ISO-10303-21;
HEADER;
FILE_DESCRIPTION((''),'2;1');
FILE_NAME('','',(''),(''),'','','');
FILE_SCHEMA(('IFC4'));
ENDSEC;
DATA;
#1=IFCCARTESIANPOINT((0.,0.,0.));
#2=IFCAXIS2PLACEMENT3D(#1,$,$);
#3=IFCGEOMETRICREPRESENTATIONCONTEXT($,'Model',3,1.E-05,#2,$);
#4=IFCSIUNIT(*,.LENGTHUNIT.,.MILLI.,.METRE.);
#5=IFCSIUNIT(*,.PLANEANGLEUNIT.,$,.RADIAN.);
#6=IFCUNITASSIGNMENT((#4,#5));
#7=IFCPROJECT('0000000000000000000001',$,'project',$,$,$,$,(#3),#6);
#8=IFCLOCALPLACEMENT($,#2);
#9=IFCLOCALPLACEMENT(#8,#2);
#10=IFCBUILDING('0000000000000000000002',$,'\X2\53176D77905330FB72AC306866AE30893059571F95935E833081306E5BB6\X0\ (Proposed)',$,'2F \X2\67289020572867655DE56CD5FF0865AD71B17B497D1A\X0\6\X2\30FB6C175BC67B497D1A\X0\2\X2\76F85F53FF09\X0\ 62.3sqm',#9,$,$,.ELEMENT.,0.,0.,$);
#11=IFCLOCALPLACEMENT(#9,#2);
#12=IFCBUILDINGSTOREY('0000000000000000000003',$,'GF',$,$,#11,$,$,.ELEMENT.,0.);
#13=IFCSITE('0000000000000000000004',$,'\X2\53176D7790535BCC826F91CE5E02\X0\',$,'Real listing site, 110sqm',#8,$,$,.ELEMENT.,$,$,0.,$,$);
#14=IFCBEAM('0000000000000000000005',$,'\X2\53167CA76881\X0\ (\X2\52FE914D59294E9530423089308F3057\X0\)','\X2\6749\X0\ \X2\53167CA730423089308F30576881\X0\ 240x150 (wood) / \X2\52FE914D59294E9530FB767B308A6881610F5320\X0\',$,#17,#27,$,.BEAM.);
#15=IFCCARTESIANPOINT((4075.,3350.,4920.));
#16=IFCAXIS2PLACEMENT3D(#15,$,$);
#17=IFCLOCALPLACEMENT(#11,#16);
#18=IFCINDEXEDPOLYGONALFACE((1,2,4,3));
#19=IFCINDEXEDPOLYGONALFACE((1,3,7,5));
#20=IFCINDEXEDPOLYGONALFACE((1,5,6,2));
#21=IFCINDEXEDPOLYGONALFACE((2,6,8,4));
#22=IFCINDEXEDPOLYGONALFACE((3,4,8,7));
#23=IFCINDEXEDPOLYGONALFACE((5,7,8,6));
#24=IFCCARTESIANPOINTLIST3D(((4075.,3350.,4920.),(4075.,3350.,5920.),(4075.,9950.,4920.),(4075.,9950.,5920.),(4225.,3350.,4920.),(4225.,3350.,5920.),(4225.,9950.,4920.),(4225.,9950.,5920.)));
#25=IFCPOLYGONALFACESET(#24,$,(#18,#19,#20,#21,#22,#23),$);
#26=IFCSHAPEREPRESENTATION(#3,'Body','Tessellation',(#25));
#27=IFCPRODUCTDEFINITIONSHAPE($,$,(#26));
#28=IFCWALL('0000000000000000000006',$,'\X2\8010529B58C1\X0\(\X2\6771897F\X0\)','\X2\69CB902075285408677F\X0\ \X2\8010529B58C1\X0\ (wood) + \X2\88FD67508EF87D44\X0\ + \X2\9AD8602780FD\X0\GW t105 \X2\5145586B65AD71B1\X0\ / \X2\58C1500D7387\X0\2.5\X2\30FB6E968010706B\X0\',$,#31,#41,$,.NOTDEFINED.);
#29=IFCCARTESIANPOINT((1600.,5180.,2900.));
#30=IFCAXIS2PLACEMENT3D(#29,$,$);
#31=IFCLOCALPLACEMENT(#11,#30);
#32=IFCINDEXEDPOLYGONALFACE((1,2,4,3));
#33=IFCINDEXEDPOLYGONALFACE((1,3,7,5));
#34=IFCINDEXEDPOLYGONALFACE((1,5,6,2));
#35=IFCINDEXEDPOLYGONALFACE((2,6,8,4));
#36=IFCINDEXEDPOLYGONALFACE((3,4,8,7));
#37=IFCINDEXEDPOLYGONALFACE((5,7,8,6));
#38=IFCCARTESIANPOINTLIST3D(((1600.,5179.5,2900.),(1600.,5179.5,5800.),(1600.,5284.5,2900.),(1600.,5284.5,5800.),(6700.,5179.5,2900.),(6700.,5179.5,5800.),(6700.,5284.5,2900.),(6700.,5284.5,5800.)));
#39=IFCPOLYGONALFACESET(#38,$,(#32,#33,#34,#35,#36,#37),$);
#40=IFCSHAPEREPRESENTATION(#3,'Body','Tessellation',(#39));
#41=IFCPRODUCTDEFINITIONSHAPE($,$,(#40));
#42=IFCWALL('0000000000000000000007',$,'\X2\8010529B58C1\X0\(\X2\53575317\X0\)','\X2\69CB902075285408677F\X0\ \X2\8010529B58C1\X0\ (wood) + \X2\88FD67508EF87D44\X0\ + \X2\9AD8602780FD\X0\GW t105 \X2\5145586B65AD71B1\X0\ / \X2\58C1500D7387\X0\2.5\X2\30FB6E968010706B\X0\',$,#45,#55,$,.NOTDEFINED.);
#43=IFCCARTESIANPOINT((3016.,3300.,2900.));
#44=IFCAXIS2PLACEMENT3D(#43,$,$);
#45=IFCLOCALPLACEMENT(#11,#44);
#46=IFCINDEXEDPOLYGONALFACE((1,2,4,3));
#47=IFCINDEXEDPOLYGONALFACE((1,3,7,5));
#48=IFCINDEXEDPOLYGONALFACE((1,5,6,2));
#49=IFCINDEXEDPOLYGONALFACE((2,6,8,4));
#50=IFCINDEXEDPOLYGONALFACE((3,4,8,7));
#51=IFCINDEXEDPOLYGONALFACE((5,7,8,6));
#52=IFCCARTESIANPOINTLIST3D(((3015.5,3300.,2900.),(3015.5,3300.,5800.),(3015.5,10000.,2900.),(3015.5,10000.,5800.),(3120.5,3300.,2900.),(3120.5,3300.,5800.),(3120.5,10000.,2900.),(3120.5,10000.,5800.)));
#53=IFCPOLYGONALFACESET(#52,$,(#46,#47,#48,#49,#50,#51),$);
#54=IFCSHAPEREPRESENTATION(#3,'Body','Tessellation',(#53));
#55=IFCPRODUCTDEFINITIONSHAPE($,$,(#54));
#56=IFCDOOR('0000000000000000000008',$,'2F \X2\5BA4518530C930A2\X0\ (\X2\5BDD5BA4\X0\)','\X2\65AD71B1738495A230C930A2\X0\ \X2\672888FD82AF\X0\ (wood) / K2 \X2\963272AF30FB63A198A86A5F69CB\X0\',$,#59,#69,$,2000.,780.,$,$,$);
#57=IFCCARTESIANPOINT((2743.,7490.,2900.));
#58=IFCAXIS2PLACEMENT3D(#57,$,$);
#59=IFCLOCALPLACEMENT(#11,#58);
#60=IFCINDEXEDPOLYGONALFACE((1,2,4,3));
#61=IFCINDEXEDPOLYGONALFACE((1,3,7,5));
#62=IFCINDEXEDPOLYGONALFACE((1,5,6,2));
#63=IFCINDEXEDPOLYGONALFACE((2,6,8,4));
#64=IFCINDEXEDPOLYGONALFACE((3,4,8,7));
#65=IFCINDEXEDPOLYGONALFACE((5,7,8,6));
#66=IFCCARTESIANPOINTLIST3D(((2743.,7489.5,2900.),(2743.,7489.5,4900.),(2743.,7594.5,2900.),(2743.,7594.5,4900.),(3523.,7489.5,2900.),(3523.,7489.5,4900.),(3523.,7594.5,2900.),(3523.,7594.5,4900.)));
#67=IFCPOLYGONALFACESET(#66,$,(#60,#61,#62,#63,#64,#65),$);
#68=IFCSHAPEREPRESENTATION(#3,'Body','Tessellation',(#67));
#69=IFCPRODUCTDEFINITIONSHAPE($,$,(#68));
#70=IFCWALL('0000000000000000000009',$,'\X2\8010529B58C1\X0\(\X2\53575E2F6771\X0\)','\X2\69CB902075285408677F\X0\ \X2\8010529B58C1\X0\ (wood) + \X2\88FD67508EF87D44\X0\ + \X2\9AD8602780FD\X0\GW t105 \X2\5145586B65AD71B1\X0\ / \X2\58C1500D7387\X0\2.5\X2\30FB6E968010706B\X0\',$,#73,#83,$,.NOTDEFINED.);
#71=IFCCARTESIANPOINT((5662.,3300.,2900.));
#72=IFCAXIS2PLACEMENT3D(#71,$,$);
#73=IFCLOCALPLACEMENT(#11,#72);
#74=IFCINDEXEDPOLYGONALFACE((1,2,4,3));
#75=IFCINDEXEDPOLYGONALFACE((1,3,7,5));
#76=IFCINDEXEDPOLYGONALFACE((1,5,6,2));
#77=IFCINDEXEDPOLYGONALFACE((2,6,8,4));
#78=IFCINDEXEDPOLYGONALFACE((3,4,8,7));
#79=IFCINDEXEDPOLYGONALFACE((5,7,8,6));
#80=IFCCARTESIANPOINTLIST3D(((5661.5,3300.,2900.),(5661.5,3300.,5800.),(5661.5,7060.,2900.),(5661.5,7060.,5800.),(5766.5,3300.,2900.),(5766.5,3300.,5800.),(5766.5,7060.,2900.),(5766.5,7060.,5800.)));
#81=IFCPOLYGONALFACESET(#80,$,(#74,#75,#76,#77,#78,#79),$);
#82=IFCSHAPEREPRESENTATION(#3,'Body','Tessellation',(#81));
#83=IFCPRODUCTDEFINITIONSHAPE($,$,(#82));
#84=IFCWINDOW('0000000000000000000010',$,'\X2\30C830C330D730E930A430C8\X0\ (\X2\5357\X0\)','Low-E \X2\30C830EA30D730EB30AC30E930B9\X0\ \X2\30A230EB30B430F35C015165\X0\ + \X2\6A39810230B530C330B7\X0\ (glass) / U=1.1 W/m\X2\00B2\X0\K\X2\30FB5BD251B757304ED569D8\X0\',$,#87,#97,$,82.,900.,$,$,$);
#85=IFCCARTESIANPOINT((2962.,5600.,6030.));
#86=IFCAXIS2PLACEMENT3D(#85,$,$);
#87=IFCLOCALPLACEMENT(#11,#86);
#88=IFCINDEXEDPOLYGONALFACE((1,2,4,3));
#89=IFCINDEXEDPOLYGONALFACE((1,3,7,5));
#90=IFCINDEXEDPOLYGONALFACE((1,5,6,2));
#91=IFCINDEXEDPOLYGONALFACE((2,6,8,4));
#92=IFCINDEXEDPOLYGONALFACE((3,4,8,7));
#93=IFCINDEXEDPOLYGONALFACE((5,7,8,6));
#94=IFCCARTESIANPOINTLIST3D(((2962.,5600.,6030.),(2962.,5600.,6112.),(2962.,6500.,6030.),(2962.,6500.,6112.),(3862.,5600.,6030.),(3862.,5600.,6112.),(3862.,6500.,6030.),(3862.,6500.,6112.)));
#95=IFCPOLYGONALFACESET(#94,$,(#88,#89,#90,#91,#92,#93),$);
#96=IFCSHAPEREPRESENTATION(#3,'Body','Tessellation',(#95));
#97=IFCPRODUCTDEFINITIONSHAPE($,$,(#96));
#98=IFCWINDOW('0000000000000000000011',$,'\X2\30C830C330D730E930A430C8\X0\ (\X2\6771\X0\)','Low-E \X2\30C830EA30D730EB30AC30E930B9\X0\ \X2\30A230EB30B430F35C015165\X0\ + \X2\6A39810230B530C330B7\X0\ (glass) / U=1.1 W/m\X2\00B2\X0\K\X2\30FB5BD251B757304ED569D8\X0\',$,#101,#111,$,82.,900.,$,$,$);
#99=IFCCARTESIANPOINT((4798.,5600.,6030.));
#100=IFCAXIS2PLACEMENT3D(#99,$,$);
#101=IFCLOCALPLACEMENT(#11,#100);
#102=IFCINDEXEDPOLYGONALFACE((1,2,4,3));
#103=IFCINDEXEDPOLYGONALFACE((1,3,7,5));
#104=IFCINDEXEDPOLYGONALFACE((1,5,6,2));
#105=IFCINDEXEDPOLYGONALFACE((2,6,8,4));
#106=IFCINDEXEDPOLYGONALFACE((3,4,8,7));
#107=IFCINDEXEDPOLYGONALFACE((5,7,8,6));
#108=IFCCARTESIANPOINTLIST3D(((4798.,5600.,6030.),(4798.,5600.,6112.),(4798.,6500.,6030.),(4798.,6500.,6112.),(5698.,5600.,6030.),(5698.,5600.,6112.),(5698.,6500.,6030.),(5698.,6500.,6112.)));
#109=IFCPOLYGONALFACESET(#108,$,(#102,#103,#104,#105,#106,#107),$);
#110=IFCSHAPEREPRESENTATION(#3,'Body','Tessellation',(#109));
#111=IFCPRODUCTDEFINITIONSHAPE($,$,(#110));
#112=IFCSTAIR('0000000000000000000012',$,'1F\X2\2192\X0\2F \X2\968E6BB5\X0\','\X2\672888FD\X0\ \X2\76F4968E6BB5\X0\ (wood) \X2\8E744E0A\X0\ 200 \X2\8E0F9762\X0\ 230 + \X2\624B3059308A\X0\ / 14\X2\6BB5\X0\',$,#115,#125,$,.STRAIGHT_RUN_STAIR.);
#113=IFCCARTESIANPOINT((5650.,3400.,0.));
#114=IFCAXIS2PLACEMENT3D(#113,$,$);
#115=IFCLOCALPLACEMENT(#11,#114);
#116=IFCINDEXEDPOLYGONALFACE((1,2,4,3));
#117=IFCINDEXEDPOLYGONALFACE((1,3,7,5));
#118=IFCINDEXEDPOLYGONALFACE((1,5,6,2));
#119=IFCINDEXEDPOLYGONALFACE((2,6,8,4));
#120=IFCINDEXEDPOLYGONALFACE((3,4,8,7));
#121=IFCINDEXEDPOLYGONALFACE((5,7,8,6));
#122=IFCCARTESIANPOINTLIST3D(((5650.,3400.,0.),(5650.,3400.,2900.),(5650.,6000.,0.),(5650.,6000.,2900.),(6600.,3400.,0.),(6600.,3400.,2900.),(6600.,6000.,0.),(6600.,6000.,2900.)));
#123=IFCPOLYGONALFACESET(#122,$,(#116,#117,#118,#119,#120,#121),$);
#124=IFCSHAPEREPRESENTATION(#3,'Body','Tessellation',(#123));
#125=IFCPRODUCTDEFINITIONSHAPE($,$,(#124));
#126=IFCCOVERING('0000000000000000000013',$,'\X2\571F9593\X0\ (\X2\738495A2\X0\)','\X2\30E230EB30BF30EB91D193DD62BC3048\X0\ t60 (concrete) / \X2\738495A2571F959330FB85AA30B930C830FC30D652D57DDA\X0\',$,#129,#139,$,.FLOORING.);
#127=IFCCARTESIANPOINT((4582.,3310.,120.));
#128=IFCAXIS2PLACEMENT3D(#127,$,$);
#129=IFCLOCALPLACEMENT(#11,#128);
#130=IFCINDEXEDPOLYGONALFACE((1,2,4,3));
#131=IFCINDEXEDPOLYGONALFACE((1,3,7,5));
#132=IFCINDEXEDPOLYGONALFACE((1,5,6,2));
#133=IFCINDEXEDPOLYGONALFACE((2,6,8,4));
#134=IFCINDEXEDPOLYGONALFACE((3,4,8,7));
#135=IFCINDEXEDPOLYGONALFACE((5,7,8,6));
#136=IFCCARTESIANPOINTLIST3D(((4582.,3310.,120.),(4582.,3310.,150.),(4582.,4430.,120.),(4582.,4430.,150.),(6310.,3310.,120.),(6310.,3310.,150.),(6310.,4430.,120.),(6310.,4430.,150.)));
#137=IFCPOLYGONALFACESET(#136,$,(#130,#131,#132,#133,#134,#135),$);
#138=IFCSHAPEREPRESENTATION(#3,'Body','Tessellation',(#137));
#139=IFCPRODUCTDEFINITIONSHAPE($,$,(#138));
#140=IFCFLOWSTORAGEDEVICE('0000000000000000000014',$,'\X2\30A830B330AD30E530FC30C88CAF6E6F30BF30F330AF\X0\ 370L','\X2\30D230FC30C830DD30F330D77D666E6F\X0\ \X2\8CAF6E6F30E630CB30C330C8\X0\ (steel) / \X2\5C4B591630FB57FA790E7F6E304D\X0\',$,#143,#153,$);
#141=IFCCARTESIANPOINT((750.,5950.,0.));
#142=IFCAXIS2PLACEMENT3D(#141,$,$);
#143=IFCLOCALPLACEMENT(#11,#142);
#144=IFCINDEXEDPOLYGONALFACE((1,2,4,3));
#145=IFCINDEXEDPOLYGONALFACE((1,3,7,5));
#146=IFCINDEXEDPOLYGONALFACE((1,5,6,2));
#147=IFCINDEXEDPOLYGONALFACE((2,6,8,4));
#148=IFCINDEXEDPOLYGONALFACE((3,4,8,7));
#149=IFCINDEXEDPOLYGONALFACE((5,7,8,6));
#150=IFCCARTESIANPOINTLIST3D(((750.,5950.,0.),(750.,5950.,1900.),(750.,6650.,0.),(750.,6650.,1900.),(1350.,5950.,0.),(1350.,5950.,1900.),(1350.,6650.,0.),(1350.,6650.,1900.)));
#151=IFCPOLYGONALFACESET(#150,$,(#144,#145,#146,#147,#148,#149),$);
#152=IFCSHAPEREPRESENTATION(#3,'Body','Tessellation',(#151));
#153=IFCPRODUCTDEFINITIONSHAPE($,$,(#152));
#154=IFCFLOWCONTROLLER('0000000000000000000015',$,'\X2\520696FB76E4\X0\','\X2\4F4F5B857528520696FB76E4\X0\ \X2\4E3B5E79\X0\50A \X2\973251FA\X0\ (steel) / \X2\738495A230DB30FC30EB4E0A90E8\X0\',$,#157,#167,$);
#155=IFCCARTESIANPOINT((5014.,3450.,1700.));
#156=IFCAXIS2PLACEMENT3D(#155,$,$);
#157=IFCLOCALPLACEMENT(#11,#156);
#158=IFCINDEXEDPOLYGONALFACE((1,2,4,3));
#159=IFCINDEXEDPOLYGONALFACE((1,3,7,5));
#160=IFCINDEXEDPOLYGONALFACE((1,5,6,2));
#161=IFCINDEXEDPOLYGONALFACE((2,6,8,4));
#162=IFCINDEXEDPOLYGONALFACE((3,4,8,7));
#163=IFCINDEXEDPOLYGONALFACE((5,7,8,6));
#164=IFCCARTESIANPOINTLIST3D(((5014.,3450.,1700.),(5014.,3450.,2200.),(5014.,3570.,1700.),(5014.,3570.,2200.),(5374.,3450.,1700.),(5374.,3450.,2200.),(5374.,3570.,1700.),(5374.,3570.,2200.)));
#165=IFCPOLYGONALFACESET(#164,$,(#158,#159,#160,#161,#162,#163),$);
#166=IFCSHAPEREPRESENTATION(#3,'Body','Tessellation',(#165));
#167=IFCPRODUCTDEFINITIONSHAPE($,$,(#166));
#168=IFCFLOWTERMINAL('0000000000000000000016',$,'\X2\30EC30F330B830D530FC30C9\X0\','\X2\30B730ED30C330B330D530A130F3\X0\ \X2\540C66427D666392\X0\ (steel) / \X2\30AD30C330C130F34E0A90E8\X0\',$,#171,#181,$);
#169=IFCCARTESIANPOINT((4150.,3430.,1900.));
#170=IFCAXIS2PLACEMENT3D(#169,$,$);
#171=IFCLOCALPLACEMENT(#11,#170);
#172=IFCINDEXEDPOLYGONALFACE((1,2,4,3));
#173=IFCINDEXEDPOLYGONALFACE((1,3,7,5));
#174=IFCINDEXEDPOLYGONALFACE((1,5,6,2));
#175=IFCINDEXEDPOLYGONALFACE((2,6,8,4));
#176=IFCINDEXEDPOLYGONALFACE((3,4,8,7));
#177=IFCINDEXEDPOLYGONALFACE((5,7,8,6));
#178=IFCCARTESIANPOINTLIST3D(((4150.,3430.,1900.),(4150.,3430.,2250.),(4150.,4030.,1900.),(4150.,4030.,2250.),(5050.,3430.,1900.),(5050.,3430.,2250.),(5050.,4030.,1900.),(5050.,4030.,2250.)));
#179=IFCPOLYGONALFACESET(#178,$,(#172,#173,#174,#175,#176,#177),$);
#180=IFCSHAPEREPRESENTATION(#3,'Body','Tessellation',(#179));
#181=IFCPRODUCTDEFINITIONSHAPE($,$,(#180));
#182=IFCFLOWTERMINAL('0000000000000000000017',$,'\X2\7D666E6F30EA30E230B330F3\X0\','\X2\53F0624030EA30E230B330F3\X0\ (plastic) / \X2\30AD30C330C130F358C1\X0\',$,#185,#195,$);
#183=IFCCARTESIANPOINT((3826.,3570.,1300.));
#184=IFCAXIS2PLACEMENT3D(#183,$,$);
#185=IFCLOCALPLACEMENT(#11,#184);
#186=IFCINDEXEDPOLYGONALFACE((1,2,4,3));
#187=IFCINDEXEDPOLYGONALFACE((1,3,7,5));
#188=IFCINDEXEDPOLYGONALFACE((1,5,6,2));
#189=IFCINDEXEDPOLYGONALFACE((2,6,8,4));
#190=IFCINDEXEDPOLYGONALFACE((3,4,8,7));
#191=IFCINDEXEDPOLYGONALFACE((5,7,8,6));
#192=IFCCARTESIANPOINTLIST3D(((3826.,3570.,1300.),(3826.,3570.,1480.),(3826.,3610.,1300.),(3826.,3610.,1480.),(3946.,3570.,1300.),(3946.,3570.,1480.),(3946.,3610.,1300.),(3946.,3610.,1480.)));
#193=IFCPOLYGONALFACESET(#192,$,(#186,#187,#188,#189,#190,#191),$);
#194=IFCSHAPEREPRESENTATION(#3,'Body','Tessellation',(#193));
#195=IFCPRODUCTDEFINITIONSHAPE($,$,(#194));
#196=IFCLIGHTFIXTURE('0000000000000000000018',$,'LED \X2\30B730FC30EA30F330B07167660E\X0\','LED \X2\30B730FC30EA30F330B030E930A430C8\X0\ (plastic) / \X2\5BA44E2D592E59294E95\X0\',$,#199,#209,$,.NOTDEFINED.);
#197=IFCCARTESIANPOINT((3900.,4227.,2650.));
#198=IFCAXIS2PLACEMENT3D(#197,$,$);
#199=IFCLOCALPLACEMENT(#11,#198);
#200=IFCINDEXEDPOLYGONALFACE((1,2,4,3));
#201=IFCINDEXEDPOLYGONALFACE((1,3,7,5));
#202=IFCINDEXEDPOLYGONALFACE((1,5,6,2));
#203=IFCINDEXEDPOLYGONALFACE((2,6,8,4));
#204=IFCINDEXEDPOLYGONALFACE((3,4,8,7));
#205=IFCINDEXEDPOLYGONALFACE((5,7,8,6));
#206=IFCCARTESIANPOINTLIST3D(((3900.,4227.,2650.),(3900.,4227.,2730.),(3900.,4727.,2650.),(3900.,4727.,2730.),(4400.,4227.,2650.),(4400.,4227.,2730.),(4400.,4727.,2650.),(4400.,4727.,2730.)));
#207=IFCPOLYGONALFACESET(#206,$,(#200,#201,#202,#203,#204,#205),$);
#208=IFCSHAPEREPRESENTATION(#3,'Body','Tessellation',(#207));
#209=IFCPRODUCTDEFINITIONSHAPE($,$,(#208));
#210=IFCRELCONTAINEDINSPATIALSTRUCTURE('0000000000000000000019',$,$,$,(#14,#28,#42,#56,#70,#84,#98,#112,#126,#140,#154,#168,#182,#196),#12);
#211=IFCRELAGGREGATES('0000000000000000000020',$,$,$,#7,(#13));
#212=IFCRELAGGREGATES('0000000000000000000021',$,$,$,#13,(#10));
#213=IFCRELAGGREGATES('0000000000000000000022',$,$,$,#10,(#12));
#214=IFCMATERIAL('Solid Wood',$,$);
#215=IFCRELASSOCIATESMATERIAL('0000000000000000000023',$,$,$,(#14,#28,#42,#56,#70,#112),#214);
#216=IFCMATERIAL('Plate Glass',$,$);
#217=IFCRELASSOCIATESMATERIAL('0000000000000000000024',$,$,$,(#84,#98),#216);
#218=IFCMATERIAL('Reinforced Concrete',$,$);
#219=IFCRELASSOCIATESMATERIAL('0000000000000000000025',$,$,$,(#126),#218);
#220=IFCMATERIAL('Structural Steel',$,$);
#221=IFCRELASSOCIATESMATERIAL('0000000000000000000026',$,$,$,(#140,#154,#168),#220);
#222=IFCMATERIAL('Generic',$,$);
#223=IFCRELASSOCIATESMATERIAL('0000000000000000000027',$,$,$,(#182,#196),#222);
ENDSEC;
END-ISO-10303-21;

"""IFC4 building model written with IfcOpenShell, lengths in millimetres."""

from ifc_helpers import new_model, si_unit, frame, frame_2d, origin, place, context, project, spatial, rectangle, extrude, material, element, fill, save


model = new_model("IFC4")

# Units and contexts
model_context = context("Model", 3, precision=1e-05, world=origin())
ifc_project = project(units=[si_unit("LENGTHUNIT", "METRE", prefix="MILLI"), si_unit("PLANEANGLEUNIT", "RADIAN")], contexts=[model_context])

# Site, building, storey
site_placement = place(None, origin())
site = spatial("IfcSite", under=ifc_project, at=site_placement, Name="北海道富良野市", ObjectType="Real listing site, 110sqm", CompositionType="ELEMENT", RefElevation=0.0)
building_placement = place(site_placement, origin())
building = spatial("IfcBuilding", under=site, at=building_placement, Name="北海道・犬と暮らす土間広めの家 (Proposed)", ObjectType="2F 木造在来工法（断熱等級6・気密等級2相当） 62.3sqm", CompositionType="ELEMENT", ElevationOfRefHeight=0.0, ElevationOfTerrain=0.0)
storey_placement = place(building_placement, origin())
storey = spatial("IfcBuildingStorey", under=building, at=storey_placement, Name="GF", CompositionType="ELEMENT", Elevation=0.0)

# Shared definitions
ifc_material_1 = material(Name="Solid Wood")

# Beam
beam_placement = place(storey_placement, frame((4075.0, 3350.0, 4920.0)))
element("IfcBeam", 1, at=beam_placement, inside=storey, material=ifc_material_1, Name="化粧梁 (勾配天井あらわし)", Description="杉 化粧あらわし梁 240x150 (wood) / 勾配天井・登り梁意匠", PredefinedType="BEAM", context=model_context, shape_type="SweptSolid", body=[
    extrude(rectangle(XDim=150.0, YDim=6600.0, at=frame_2d((75.0, 3300.0))), frame((4075.0, 3350.0, 4920.0)), (0.0, 0.0, 1.0), 1000.0),
])

# Wall
wall_1_placement = place(storey_placement, frame((1600.0, 5180.0, 2900.0)))
element("IfcWall", 2, at=wall_1_placement, inside=storey, material=ifc_material_1, Name="耐力壁(東西)", Description="構造用合板 耐力壁 (wood) + 製材軸組 + 高性能GW t105 充填断熱 / 壁倍率2.5・準耐火", PredefinedType="NOTDEFINED", context=model_context, shape_type="SweptSolid", body=[
    extrude(rectangle(XDim=5100.0, YDim=105.0, at=frame_2d((2550.0, 52.0))), frame((1600.0, 5180.0, 2900.0)), (0.0, 0.0, 1.0), 2900.0),
])

# Wall, opening, door
wall_2_placement = place(storey_placement, frame((3016.0, 3300.0, 2900.0)))
wall_2 = element("IfcWall", 3, at=wall_2_placement, inside=storey, material=ifc_material_1, Name="耐力壁(南北)", Description="構造用合板 耐力壁 (wood) + 製材軸組 + 高性能GW t105 充填断熱 / 壁倍率2.5・準耐火", PredefinedType="NOTDEFINED", context=model_context, shape_type="SweptSolid", body=[
    extrude(rectangle(XDim=105.0, YDim=6700.0, at=frame_2d((52.0, 3350.0))), frame((3016.0, 3300.0, 2900.0)), (0.0, 0.0, 1.0), 2900.0),
])
opening_placement = place(storey_placement, frame((2743.0, 7490.0, 2900.0)))
opening = element("IfcOpeningElement", 4, at=opening_placement, cuts=wall_2, PredefinedType="NOTDEFINED", context=model_context, shape_type="SweptSolid", body=[
    extrude(rectangle(XDim=780.0, YDim=105.0, at=frame_2d((390.0, 52.0))), frame((2743.0, 7490.0, 2900.0)), (0.0, 0.0, 1.0), 2000.0),
])
door_placement = place(storey_placement, frame((2743.0, 7490.0, 2900.0)))
door = element("IfcDoor", 5, at=door_placement, inside=storey, material=ifc_material_1, Name="2F 室内ドア (寝室)", Description="断熱玄関ドア 木製芯 (wood) / K2 防犯・採風機構", OverallHeight=2000.0, OverallWidth=780.0, context=model_context, shape_type="SweptSolid", body=[
    extrude(rectangle(XDim=780.0, YDim=105.0, at=frame_2d((390.0, 52.0))), frame((2743.0, 7490.0, 2900.0)), (0.0, 0.0, 1.0), 2000.0),
])
fill(opening, door)

# Wall
wall_3_placement = place(storey_placement, frame((5662.0, 3300.0, 2900.0)))
element("IfcWall", 6, at=wall_3_placement, inside=storey, material=ifc_material_1, Name="耐力壁(南帯東)", Description="構造用合板 耐力壁 (wood) + 製材軸組 + 高性能GW t105 充填断熱 / 壁倍率2.5・準耐火", PredefinedType="NOTDEFINED", context=model_context, shape_type="SweptSolid", body=[
    extrude(rectangle(XDim=105.0, YDim=3760.0, at=frame_2d((52.0, 1880.0))), frame((5662.0, 3300.0, 2900.0)), (0.0, 0.0, 1.0), 2900.0),
])

# Windows
ifc_material_2 = material(Name="Plate Glass")
window_1_placement = place(storey_placement, frame((2962.0, 5600.0, 6030.0)))
element("IfcWindow", 7, at=window_1_placement, inside=storey, material=ifc_material_2, Name="トップライト (南)", Description="Low-E トリプルガラス アルゴン封入 + 樹脂サッシ (glass) / U=1.1 W/m²K・寒冷地仕様", OverallHeight=82.0, OverallWidth=900.0, context=model_context, shape_type="SweptSolid", body=[
    extrude(rectangle(XDim=900.0, YDim=900.0, at=frame_2d((450.0, 450.0))), frame((2962.0, 5600.0, 6030.0)), (0.0, 0.0, 1.0), 82.0),
])
window_2_placement = place(storey_placement, frame((4798.0, 5600.0, 6030.0)))
element("IfcWindow", 8, at=window_2_placement, inside=storey, material=ifc_material_2, Name="トップライト (東)", Description="Low-E トリプルガラス アルゴン封入 + 樹脂サッシ (glass) / U=1.1 W/m²K・寒冷地仕様", OverallHeight=82.0, OverallWidth=900.0, context=model_context, shape_type="SweptSolid", body=[
    extrude(rectangle(XDim=900.0, YDim=900.0, at=frame_2d((450.0, 450.0))), frame((4798.0, 5600.0, 6030.0)), (0.0, 0.0, 1.0), 82.0),
])

# Stair
stair_placement = place(storey_placement, frame((5650.0, 3400.0, 0.0)))
element("IfcStair", 9, at=stair_placement, inside=storey, material=ifc_material_1, Name="1F→2F 階段", Description="木製 直階段 (wood) 蹴上 200 踏面 230 + 手すり / 14段", PredefinedType="STRAIGHT_RUN_STAIR", context=model_context, shape_type="SweptSolid", body=[
    extrude(rectangle(XDim=950.0, YDim=2600.0, at=frame_2d((475.0, 1300.0))), frame((5650.0, 3400.0, 0.0)), (0.0, 0.0, 1.0), 2900.0),
])

# Covering
ifc_material_3 = material(Name="Reinforced Concrete")
covering_placement = place(storey_placement, frame((4582.0, 3310.0, 120.0)))
element("IfcCovering", 10, at=covering_placement, inside=storey, material=ifc_material_3, Name="土間 (玄関)", Description="モルタル金鏝押え t60 (concrete) / 玄関土間・薪ストーブ動線", PredefinedType="FLOORING", context=model_context, shape_type="SweptSolid", body=[
    extrude(rectangle(XDim=1728.0, YDim=1120.0, at=frame_2d((864.0, 560.0))), frame((4582.0, 3310.0, 120.0)), (0.0, 0.0, 1.0), 30.0),
])

# Flow storage device
ifc_material_4 = material(Name="Structural Steel")
flow_storage_device_placement = place(storey_placement, frame((750.0, 5950.0, 0.0)))
element("IfcFlowStorageDevice", 11, at=flow_storage_device_placement, inside=storey, material=ifc_material_4, Name="エコキュート貯湯タンク 370L", Description="ヒートポンプ給湯 貯湯ユニット (steel) / 屋外・基礎置き", context=model_context, shape_type="SweptSolid", body=[
    extrude(rectangle(XDim=600.0, YDim=700.0, at=frame_2d((300.0, 350.0))), frame((750.0, 5950.0, 0.0)), (0.0, 0.0, 1.0), 1900.0),
])

# Flow controller
flow_controller_placement = place(storey_placement, frame((5014.0, 3450.0, 1700.0)))
element("IfcFlowController", 12, at=flow_controller_placement, inside=storey, material=ifc_material_4, Name="分電盤", Description="住宅用分電盤 主幹50A 露出 (steel) / 玄関ホール上部", context=model_context, shape_type="SweptSolid", body=[
    extrude(rectangle(XDim=360.0, YDim=120.0, at=frame_2d((180.0, 60.0))), frame((5014.0, 3450.0, 1700.0)), (0.0, 0.0, 1.0), 500.0),
])

# Flow terminals
flow_terminal_1_placement = place(storey_placement, frame((4150.0, 3430.0, 1900.0)))
element("IfcFlowTerminal", 13, at=flow_terminal_1_placement, inside=storey, material=ifc_material_4, Name="レンジフード", Description="シロッコファン 同時給排 (steel) / キッチン上部", context=model_context, shape_type="SweptSolid", body=[
    extrude(rectangle(XDim=900.0, YDim=600.0, at=frame_2d((450.0, 300.0))), frame((4150.0, 3430.0, 1900.0)), (0.0, 0.0, 1.0), 350.0),
])
ifc_material_5 = material(Name="Generic")
flow_terminal_2_placement = place(storey_placement, frame((3826.0, 3570.0, 1300.0)))
element("IfcFlowTerminal", 14, at=flow_terminal_2_placement, inside=storey, material=ifc_material_5, Name="給湯リモコン", Description="台所リモコン (plastic) / キッチン壁", context=model_context, shape_type="SweptSolid", body=[
    extrude(rectangle(XDim=120.0, YDim=40.0, at=frame_2d((60.0, 20.0))), frame((3826.0, 3570.0, 1300.0)), (0.0, 0.0, 1.0), 180.0),
])

# Light fixture
light_fixture_1_placement = place(storey_placement, frame((3900.0, 4227.0, 2650.0)))
element("IfcLightFixture", 15, at=light_fixture_1_placement, inside=storey, material=ifc_material_5, Name="LED シーリング照明", Description="LED シーリングライト (plastic) / 室中央天井", PredefinedType="NOTDEFINED", context=model_context, shape_type="SweptSolid", body=[
    extrude(rectangle(XDim=500.0, YDim=500.0, at=frame_2d((250.0, 250.0))), frame((3900.0, 4227.0, 2650.0)), (0.0, 0.0, 1.0), 80.0),
])

save(model, "model.ifc")
